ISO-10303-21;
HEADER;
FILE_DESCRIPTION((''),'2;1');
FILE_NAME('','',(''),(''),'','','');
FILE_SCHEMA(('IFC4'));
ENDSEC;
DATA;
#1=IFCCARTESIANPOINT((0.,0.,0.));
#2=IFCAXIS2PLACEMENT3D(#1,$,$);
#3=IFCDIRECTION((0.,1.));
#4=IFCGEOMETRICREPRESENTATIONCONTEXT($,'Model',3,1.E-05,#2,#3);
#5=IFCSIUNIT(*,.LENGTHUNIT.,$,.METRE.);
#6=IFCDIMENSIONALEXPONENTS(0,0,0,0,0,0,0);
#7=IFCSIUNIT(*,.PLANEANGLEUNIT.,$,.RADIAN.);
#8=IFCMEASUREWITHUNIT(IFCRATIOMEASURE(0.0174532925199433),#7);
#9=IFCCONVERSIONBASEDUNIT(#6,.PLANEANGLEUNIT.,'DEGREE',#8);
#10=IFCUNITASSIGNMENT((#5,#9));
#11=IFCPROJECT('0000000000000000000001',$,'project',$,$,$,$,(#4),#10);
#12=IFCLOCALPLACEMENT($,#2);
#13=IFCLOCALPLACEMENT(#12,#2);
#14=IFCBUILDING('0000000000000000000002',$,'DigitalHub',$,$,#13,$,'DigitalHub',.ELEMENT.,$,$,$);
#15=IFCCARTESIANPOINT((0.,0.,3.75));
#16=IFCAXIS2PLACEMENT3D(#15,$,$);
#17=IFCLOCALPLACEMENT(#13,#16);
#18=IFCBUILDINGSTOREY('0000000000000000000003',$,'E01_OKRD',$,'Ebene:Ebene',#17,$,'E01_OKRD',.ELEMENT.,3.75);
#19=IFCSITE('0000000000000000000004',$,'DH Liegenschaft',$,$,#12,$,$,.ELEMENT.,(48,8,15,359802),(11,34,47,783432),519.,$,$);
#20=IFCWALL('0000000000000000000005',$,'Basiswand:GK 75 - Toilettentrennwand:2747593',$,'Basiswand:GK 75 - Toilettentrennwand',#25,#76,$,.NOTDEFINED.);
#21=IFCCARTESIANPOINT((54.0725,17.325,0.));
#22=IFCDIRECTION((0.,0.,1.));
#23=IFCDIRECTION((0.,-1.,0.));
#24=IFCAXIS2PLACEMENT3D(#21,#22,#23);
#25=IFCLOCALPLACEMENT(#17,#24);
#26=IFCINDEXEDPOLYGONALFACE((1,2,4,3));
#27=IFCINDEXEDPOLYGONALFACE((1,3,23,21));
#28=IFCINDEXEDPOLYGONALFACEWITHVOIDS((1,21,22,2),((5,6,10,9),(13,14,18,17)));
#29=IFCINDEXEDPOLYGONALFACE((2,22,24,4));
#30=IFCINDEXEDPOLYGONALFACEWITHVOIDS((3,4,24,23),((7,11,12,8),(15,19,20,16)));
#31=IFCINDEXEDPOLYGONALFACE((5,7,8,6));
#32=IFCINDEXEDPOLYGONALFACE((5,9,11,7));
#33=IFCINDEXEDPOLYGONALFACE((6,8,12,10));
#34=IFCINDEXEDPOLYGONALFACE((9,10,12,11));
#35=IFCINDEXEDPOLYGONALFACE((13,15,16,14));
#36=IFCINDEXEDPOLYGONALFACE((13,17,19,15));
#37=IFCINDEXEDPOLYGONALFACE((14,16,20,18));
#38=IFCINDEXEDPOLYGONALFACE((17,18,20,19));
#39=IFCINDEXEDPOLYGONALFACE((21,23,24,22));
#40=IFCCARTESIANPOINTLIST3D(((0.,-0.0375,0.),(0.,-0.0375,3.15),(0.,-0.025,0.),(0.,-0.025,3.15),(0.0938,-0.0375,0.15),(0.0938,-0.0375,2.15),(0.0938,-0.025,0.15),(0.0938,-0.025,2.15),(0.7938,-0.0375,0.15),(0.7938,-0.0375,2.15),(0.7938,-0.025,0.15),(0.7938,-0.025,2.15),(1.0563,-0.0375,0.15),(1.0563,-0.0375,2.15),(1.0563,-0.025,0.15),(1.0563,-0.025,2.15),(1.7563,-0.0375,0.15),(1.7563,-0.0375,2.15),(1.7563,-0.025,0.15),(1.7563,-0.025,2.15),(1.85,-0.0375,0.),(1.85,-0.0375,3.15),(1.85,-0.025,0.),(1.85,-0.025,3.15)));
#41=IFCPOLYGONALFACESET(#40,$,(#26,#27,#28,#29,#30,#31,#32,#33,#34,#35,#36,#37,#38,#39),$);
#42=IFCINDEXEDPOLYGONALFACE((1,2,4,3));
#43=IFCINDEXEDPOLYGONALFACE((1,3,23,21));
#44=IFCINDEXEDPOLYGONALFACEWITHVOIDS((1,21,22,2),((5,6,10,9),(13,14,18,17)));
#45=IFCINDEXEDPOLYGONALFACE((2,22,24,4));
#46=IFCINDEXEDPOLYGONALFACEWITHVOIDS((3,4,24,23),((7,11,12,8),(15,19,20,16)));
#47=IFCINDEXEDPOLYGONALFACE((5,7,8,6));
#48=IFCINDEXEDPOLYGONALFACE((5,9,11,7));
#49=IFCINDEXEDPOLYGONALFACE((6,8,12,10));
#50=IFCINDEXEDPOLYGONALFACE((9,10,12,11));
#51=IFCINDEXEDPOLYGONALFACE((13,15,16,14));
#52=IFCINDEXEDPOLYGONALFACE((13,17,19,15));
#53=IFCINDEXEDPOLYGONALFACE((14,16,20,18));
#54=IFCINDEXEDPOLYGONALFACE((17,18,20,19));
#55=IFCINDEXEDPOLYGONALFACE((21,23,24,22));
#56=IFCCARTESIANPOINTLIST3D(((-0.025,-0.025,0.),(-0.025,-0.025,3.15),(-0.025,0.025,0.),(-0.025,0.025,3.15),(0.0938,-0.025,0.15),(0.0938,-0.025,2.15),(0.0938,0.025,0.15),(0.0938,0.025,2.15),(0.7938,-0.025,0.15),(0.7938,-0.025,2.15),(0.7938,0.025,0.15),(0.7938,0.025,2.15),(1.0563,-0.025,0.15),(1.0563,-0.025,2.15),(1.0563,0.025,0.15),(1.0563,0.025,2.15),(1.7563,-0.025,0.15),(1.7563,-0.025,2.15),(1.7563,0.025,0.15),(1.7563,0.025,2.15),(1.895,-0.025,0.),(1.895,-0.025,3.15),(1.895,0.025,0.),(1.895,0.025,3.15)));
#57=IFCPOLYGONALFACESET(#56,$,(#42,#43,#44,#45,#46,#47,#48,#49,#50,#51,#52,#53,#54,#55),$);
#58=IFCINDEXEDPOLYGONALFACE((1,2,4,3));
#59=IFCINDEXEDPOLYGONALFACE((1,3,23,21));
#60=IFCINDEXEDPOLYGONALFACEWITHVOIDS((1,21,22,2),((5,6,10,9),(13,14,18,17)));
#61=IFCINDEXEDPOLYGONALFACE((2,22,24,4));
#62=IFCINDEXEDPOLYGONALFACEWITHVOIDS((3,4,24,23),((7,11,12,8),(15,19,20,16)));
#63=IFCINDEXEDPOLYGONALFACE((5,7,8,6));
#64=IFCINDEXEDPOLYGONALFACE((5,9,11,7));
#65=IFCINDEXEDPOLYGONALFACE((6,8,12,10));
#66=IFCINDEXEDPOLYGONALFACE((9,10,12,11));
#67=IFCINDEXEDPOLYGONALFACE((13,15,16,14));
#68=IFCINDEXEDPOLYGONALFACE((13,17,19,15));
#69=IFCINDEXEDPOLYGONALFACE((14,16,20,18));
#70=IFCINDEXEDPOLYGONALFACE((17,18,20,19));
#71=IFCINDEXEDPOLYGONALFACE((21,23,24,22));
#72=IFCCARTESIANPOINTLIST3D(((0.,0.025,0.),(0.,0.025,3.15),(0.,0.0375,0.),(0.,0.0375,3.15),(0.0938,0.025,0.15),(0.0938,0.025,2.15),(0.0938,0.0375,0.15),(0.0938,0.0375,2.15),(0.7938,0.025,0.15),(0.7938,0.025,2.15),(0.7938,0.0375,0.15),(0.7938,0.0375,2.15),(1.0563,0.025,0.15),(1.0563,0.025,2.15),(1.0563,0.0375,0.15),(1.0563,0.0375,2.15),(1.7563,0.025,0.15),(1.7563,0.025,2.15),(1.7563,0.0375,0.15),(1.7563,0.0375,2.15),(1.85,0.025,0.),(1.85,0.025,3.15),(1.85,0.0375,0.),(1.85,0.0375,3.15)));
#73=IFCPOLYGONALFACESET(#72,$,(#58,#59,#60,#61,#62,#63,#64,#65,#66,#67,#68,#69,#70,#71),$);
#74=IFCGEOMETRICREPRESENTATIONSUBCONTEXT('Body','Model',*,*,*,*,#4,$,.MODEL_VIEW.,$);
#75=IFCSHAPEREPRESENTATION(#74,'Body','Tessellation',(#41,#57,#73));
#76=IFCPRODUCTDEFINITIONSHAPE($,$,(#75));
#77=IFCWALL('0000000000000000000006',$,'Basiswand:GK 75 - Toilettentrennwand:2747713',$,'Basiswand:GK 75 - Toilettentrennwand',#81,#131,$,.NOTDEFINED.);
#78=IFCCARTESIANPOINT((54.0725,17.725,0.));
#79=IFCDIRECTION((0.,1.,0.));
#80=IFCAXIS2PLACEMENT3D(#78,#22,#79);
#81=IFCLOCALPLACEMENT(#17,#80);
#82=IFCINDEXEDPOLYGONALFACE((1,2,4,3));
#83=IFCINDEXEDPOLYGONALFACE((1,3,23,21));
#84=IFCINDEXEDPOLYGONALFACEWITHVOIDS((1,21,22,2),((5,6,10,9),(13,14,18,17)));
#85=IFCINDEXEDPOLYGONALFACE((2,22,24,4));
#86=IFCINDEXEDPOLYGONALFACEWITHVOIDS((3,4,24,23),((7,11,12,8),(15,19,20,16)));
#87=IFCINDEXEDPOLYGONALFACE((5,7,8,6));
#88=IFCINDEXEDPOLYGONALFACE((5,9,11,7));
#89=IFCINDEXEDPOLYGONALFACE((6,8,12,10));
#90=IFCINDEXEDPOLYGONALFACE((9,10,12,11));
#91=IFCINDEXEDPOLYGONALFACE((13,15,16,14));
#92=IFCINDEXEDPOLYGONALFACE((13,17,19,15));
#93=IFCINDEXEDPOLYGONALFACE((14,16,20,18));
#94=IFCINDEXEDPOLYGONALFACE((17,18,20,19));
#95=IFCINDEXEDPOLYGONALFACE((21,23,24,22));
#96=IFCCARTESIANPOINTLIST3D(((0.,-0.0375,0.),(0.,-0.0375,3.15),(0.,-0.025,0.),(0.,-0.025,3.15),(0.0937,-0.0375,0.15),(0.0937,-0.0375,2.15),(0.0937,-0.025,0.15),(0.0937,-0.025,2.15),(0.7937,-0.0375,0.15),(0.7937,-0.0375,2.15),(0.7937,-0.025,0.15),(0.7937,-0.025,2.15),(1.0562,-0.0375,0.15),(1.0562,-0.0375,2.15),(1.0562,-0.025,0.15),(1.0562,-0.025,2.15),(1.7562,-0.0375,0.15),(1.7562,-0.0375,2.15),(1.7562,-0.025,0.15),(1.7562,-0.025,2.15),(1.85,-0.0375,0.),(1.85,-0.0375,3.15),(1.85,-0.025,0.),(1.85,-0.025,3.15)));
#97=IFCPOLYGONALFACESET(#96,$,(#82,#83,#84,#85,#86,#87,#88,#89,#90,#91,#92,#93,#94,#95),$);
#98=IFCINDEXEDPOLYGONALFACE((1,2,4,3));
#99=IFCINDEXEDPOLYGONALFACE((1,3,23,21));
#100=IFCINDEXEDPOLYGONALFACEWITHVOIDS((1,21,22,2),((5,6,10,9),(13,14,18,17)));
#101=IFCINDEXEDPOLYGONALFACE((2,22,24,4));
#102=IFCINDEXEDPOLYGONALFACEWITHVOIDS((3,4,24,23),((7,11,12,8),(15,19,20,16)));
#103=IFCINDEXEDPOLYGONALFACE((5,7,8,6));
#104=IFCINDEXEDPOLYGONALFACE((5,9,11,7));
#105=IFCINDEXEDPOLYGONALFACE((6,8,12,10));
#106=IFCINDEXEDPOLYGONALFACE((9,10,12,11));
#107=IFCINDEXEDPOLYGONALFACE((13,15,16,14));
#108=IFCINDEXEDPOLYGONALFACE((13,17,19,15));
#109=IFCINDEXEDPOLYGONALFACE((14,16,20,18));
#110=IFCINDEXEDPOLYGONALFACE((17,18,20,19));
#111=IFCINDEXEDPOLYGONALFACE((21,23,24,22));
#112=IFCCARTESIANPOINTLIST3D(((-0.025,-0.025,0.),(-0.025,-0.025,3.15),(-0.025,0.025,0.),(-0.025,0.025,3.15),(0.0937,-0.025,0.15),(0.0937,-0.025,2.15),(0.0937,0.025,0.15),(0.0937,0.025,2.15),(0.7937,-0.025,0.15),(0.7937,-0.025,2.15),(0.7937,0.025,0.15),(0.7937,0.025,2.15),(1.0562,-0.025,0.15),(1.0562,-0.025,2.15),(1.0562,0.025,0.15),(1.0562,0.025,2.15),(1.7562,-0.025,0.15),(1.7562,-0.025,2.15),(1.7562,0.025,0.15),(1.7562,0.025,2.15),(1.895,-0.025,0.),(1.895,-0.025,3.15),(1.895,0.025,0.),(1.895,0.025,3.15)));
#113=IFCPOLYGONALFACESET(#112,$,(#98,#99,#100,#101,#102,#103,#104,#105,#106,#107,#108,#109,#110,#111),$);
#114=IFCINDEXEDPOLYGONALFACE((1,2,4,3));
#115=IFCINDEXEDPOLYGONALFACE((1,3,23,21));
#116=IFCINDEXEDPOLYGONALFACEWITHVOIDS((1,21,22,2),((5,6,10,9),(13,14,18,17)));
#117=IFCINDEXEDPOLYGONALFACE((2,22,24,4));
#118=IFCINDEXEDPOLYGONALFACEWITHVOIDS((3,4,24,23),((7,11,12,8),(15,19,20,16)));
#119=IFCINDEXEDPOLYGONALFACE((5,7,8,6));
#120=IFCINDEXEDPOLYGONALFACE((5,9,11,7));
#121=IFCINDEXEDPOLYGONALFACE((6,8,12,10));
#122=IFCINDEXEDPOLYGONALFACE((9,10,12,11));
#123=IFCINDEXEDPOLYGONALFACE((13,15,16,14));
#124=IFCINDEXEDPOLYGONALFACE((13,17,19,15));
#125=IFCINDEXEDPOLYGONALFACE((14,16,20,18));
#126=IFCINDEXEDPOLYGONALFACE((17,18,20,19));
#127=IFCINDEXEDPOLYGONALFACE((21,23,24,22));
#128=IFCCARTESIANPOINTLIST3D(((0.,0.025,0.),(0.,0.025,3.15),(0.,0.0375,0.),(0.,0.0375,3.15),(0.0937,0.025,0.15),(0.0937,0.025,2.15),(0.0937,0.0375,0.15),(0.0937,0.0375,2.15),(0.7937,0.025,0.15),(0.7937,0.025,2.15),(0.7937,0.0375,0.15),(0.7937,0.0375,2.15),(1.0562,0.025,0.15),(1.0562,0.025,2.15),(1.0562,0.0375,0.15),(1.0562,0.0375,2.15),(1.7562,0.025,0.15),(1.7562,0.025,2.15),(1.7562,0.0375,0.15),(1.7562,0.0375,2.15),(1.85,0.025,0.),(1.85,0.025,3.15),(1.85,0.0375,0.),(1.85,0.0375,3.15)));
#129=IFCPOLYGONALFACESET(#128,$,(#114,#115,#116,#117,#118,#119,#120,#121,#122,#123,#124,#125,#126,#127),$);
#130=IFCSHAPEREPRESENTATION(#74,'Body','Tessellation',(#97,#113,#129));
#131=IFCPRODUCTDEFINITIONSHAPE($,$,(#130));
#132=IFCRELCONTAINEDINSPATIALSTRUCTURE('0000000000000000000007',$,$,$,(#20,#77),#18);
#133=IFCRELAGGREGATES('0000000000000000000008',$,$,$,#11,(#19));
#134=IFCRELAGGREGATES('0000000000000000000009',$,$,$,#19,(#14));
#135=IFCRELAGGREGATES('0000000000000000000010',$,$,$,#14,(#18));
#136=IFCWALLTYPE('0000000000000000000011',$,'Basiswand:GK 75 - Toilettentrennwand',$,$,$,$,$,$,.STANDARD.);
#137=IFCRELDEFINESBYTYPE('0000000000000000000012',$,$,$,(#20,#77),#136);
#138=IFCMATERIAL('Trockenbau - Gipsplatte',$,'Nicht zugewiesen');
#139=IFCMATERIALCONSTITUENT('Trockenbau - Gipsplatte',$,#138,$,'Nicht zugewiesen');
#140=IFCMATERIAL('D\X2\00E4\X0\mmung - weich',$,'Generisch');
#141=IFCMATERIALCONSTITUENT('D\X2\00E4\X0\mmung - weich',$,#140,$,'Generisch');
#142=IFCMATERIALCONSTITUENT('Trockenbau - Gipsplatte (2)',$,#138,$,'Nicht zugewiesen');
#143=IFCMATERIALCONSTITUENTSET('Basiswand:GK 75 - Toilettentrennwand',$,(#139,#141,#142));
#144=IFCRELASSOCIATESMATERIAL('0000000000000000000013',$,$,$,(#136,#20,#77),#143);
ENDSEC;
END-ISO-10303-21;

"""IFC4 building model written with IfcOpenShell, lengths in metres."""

from ifc_helpers import new_model, entity, si_unit, converted_unit, direction, frame, origin, place, context, subcontext, project, spatial, indexed_curve, outline, extrude, material, constituent, constituent_set, type_object, element, save


model = new_model("IFC4")

# Units and contexts
model_context = context("Model", 3, precision=1e-05, world=origin(), true_north=direction((0.0, 1.0)))
body_context = subcontext(model_context, "Body", "Model", "MODEL_VIEW")
ifc_project = project(units=[si_unit("LENGTHUNIT", "METRE"), converted_unit("PLANEANGLEUNIT", "DEGREE", entity("IfcRatioMeasure", 0.0174532925199433), si_unit("PLANEANGLEUNIT", "RADIAN"), dimensions=[0, 0, 0, 0, 0, 0, 0])], contexts=[model_context])

# Site, building, storey
site_placement = place(None, frame((0.0, 0.0, 0.0)))
site = spatial("IfcSite", under=ifc_project, at=site_placement, Name="DH Liegenschaft", CompositionType="ELEMENT", RefLatitude=(48, 8, 15, 359802), RefLongitude=(11, 34, 47, 783432), RefElevation=519.0)
building_placement = place(site_placement, origin())
building = spatial("IfcBuilding", under=site, at=building_placement, Name="DigitalHub", LongName="DigitalHub", CompositionType="ELEMENT")
storey_placement = place(building_placement, frame((0.0, 0.0, 3.75)))
storey = spatial("IfcBuildingStorey", under=building, at=storey_placement, Name="E01_OKRD", ObjectType="Ebene:Ebene", LongName="E01_OKRD", CompositionType="ELEMENT", Elevation=3.75)

# Shared definitions
ifc_material_1 = material(Name="Trockenbau - Gipsplatte", Category="Nicht zugewiesen")
ifc_material_2 = material(Name="Dämmung - weich", Category="Generisch")

# Walls, openings
ifc_constituent_1 = constituent(ifc_material_1, Name="Trockenbau - Gipsplatte", Category="Nicht zugewiesen")
ifc_constituent_2 = constituent(ifc_material_2, Name="Dämmung - weich", Category="Generisch")
ifc_constituent_3 = constituent(ifc_material_1, Name="Trockenbau - Gipsplatte (2)", Category="Nicht zugewiesen")
ifc_constituent_set_1 = constituent_set(constituents=[ifc_constituent_1, ifc_constituent_2, ifc_constituent_3], Name="Basiswand:GK 75 - Toilettentrennwand")
wall_type_1 = type_object("IfcWallType", Name="Basiswand:GK 75 - Toilettentrennwand", PredefinedType="STANDARD", material=ifc_constituent_set_1)
wall_1_placement = place(storey_placement, frame((54.0725, 17.325, 0.0), z_axis=(0.0, 0.0, 1.0), x_axis=(0.0, -1.0, 0.0)))
wall_1 = element("IfcWall", 1, at=wall_1_placement, inside=storey, type_object=wall_type_1, material=ifc_constituent_set_1, Name="Basiswand:GK 75 - Toilettentrennwand:2747593", ObjectType="Basiswand:GK 75 - Toilettentrennwand", PredefinedType="NOTDEFINED", context=body_context, shape_type="SweptSolid", body=[
    extrude(outline(indexed_curve([(-1.575, -0.925), (1.575, -0.925), (1.575, 0.925), (-1.575, 0.925), (-1.575, -0.925)], self_intersect=False), holes=[indexed_curve([(0.575, -0.8313), (-1.425, -0.8313), (-1.425, -0.1313), (0.575, -0.1313), (0.575, -0.8313)], self_intersect=False), indexed_curve([(0.575, 0.1312), (-1.425, 0.1312), (-1.425, 0.8312), (0.575, 0.8312), (0.575, 0.1312)], self_intersect=False)]), frame((0.925, -0.0375, 1.575), z_axis=(0.0, 1.0, 0.0), x_axis=(0.0, 0.0, 1.0)), (0.0, 0.0, 1.0), 0.0125),
    extrude(outline(indexed_curve([(-1.575, -0.96), (1.575, -0.96), (1.575, 0.96), (-1.575, 0.96), (-1.575, -0.96)], self_intersect=False), holes=[indexed_curve([(0.575, 0.1213), (-1.425, 0.1213), (-1.425, 0.8213), (0.575, 0.8213), (0.575, 0.1213)], self_intersect=False), indexed_curve([(0.575, -0.8413), (-1.425, -0.8412), (-1.425, -0.1413), (0.575, -0.1413), (0.575, -0.8413)], self_intersect=False)]), frame((0.935, -0.025, 1.575), z_axis=(0.0, 1.0, 0.0), x_axis=(0.0, 0.0, 1.0)), (0.0, 0.0, 1.0), 0.05),
    extrude(outline(indexed_curve([(-1.575, -0.925), (1.575, -0.925), (1.575, 0.925), (-1.575, 0.925), (-1.575, -0.925)], self_intersect=False), holes=[indexed_curve([(0.575, 0.1312), (-1.425, 0.1312), (-1.425, 0.8312), (0.575, 0.8312), (0.575, 0.1312)], self_intersect=False), indexed_curve([(0.575, -0.8313), (-1.425, -0.8313), (-1.425, -0.1313), (0.575, -0.1313), (0.575, -0.8313)], self_intersect=False)]), frame((0.925, 0.025, 1.575), z_axis=(0.0, 1.0, 0.0), x_axis=(0.0, 0.0, 1.0)), (0.0, 0.0, 1.0), 0.0125),
])
opening_1_placement = place(wall_1_placement, frame((0.7937, -0.0375, 0.15)))
element("IfcOpeningElement", 2, at=opening_1_placement, cuts=wall_1, PredefinedType="OPENING", context=body_context, shape_type="SweptSolid", body=[
    extrude(outline(indexed_curve([(-1.0, -0.35), (1.0, -0.35), (1.0, 0.35), (-1.0, 0.35), (-1.0, -0.35)], self_intersect=False)), frame((-0.35, 0.0, 1.0), z_axis=(0.0, 1.0, 0.0), x_axis=(0.0, 0.0, -1.0)), (0.0, 0.0, 1.0), 0.075),
])
opening_2_placement = place(wall_1_placement, frame((1.7563, -0.0375, 0.15)))
element("IfcOpeningElement", 3, at=opening_2_placement, cuts=wall_1, PredefinedType="OPENING", context=body_context, shape_type="SweptSolid", body=[
    extrude(outline(indexed_curve([(-1.0, -0.35), (1.0, -0.35), (1.0, 0.35), (-1.0, 0.35), (-1.0, -0.35)], self_intersect=False)), frame((-0.35, 0.0, 1.0), z_axis=(0.0, 1.0, 0.0), x_axis=(0.0, 0.0, -1.0)), (0.0, 0.0, 1.0), 0.075),
])
wall_2_placement = place(storey_placement, frame((54.0725, 17.725, 0.0), z_axis=(0.0, 0.0, 1.0), x_axis=(0.0, 1.0, 0.0)))
wall_2 = element("IfcWall", 4, at=wall_2_placement, inside=storey, type_object=wall_type_1, material=ifc_constituent_set_1, Name="Basiswand:GK 75 - Toilettentrennwand:2747713", ObjectType="Basiswand:GK 75 - Toilettentrennwand", PredefinedType="NOTDEFINED", context=body_context, shape_type="SweptSolid", body=[
    extrude(outline(indexed_curve([(-1.575, -0.925), (1.575, -0.925), (1.575, 0.925), (-1.575, 0.925), (-1.575, -0.925)], self_intersect=False), holes=[indexed_curve([(0.575, -0.8313), (-1.425, -0.8313), (-1.425, -0.1313), (0.575, -0.1313), (0.575, -0.8313)], self_intersect=False), indexed_curve([(0.575, 0.1313), (-1.425, 0.1313), (-1.425, 0.8313), (0.575, 0.8313), (0.575, 0.1313)], self_intersect=False)]), frame((0.925, -0.025, 1.575), z_axis=(0.0, -1.0, 0.0), x_axis=(0.0, 0.0, 1.0)), (0.0, 0.0, 1.0), 0.0125),
    extrude(outline(indexed_curve([(-1.575, -0.96), (1.575, -0.96), (1.575, 0.96), (-1.575, 0.96), (-1.575, -0.96)], self_intersect=False), holes=[indexed_curve([(0.575, -0.8213), (-1.425, -0.8213), (-1.425, -0.1213), (0.575, -0.1213), (0.575, -0.8213)], self_intersect=False), indexed_curve([(0.575, 0.1413), (-1.425, 0.1413), (-1.425, 0.8413), (0.575, 0.8413), (0.575, 0.1413)], self_intersect=False)]), frame((0.935, 0.025, 1.575), z_axis=(0.0, -1.0, 0.0), x_axis=(0.0, 0.0, 1.0)), (0.0, 0.0, 1.0), 0.05),
    extrude(outline(indexed_curve([(-1.575, -0.925), (1.575, -0.925), (1.575, 0.925), (-1.575, 0.925), (-1.575, -0.925)], self_intersect=False), holes=[indexed_curve([(0.575, 0.1313), (-1.425, 0.1313), (-1.425, 0.8313), (0.575, 0.8313), (0.575, 0.1313)], self_intersect=False), indexed_curve([(0.575, -0.8313), (-1.425, -0.8313), (-1.425, -0.1313), (0.575, -0.1313), (0.575, -0.8313)], self_intersect=False)]), frame((0.925, 0.0375, 1.575), z_axis=(0.0, -1.0, 0.0), x_axis=(0.0, 0.0, 1.0)), (0.0, 0.0, 1.0), 0.0125),
])
opening_3_placement = place(wall_2_placement, frame((1.0563, 0.0375, 0.15)))
element("IfcOpeningElement", 5, at=opening_3_placement, cuts=wall_2, PredefinedType="OPENING", context=body_context, shape_type="SweptSolid", body=[
    extrude(outline(indexed_curve([(-1.0, -0.35), (1.0, -0.35), (1.0, 0.35), (-1.0, 0.35), (-1.0, -0.35)], self_intersect=False)), frame((0.35, -0.075, 1.0), z_axis=(0.0, 1.0, 0.0), x_axis=(0.0, 0.0, -1.0)), (0.0, 0.0, 1.0), 0.075),
])
opening_4_placement = place(wall_2_placement, frame((0.0938, 0.0375, 0.15)))
element("IfcOpeningElement", 6, at=opening_4_placement, cuts=wall_2, PredefinedType="OPENING", context=body_context, shape_type="SweptSolid", body=[
    extrude(outline(indexed_curve([(-1.0, -0.35), (1.0, -0.35), (1.0, 0.35), (-1.0, 0.35), (-1.0, -0.35)], self_intersect=False)), frame((0.35, -0.075, 1.0), z_axis=(0.0, 1.0, 0.0), x_axis=(0.0, 0.0, -1.0)), (0.0, 0.0, 1.0), 0.075),
])

save(model, "model.ifc")
